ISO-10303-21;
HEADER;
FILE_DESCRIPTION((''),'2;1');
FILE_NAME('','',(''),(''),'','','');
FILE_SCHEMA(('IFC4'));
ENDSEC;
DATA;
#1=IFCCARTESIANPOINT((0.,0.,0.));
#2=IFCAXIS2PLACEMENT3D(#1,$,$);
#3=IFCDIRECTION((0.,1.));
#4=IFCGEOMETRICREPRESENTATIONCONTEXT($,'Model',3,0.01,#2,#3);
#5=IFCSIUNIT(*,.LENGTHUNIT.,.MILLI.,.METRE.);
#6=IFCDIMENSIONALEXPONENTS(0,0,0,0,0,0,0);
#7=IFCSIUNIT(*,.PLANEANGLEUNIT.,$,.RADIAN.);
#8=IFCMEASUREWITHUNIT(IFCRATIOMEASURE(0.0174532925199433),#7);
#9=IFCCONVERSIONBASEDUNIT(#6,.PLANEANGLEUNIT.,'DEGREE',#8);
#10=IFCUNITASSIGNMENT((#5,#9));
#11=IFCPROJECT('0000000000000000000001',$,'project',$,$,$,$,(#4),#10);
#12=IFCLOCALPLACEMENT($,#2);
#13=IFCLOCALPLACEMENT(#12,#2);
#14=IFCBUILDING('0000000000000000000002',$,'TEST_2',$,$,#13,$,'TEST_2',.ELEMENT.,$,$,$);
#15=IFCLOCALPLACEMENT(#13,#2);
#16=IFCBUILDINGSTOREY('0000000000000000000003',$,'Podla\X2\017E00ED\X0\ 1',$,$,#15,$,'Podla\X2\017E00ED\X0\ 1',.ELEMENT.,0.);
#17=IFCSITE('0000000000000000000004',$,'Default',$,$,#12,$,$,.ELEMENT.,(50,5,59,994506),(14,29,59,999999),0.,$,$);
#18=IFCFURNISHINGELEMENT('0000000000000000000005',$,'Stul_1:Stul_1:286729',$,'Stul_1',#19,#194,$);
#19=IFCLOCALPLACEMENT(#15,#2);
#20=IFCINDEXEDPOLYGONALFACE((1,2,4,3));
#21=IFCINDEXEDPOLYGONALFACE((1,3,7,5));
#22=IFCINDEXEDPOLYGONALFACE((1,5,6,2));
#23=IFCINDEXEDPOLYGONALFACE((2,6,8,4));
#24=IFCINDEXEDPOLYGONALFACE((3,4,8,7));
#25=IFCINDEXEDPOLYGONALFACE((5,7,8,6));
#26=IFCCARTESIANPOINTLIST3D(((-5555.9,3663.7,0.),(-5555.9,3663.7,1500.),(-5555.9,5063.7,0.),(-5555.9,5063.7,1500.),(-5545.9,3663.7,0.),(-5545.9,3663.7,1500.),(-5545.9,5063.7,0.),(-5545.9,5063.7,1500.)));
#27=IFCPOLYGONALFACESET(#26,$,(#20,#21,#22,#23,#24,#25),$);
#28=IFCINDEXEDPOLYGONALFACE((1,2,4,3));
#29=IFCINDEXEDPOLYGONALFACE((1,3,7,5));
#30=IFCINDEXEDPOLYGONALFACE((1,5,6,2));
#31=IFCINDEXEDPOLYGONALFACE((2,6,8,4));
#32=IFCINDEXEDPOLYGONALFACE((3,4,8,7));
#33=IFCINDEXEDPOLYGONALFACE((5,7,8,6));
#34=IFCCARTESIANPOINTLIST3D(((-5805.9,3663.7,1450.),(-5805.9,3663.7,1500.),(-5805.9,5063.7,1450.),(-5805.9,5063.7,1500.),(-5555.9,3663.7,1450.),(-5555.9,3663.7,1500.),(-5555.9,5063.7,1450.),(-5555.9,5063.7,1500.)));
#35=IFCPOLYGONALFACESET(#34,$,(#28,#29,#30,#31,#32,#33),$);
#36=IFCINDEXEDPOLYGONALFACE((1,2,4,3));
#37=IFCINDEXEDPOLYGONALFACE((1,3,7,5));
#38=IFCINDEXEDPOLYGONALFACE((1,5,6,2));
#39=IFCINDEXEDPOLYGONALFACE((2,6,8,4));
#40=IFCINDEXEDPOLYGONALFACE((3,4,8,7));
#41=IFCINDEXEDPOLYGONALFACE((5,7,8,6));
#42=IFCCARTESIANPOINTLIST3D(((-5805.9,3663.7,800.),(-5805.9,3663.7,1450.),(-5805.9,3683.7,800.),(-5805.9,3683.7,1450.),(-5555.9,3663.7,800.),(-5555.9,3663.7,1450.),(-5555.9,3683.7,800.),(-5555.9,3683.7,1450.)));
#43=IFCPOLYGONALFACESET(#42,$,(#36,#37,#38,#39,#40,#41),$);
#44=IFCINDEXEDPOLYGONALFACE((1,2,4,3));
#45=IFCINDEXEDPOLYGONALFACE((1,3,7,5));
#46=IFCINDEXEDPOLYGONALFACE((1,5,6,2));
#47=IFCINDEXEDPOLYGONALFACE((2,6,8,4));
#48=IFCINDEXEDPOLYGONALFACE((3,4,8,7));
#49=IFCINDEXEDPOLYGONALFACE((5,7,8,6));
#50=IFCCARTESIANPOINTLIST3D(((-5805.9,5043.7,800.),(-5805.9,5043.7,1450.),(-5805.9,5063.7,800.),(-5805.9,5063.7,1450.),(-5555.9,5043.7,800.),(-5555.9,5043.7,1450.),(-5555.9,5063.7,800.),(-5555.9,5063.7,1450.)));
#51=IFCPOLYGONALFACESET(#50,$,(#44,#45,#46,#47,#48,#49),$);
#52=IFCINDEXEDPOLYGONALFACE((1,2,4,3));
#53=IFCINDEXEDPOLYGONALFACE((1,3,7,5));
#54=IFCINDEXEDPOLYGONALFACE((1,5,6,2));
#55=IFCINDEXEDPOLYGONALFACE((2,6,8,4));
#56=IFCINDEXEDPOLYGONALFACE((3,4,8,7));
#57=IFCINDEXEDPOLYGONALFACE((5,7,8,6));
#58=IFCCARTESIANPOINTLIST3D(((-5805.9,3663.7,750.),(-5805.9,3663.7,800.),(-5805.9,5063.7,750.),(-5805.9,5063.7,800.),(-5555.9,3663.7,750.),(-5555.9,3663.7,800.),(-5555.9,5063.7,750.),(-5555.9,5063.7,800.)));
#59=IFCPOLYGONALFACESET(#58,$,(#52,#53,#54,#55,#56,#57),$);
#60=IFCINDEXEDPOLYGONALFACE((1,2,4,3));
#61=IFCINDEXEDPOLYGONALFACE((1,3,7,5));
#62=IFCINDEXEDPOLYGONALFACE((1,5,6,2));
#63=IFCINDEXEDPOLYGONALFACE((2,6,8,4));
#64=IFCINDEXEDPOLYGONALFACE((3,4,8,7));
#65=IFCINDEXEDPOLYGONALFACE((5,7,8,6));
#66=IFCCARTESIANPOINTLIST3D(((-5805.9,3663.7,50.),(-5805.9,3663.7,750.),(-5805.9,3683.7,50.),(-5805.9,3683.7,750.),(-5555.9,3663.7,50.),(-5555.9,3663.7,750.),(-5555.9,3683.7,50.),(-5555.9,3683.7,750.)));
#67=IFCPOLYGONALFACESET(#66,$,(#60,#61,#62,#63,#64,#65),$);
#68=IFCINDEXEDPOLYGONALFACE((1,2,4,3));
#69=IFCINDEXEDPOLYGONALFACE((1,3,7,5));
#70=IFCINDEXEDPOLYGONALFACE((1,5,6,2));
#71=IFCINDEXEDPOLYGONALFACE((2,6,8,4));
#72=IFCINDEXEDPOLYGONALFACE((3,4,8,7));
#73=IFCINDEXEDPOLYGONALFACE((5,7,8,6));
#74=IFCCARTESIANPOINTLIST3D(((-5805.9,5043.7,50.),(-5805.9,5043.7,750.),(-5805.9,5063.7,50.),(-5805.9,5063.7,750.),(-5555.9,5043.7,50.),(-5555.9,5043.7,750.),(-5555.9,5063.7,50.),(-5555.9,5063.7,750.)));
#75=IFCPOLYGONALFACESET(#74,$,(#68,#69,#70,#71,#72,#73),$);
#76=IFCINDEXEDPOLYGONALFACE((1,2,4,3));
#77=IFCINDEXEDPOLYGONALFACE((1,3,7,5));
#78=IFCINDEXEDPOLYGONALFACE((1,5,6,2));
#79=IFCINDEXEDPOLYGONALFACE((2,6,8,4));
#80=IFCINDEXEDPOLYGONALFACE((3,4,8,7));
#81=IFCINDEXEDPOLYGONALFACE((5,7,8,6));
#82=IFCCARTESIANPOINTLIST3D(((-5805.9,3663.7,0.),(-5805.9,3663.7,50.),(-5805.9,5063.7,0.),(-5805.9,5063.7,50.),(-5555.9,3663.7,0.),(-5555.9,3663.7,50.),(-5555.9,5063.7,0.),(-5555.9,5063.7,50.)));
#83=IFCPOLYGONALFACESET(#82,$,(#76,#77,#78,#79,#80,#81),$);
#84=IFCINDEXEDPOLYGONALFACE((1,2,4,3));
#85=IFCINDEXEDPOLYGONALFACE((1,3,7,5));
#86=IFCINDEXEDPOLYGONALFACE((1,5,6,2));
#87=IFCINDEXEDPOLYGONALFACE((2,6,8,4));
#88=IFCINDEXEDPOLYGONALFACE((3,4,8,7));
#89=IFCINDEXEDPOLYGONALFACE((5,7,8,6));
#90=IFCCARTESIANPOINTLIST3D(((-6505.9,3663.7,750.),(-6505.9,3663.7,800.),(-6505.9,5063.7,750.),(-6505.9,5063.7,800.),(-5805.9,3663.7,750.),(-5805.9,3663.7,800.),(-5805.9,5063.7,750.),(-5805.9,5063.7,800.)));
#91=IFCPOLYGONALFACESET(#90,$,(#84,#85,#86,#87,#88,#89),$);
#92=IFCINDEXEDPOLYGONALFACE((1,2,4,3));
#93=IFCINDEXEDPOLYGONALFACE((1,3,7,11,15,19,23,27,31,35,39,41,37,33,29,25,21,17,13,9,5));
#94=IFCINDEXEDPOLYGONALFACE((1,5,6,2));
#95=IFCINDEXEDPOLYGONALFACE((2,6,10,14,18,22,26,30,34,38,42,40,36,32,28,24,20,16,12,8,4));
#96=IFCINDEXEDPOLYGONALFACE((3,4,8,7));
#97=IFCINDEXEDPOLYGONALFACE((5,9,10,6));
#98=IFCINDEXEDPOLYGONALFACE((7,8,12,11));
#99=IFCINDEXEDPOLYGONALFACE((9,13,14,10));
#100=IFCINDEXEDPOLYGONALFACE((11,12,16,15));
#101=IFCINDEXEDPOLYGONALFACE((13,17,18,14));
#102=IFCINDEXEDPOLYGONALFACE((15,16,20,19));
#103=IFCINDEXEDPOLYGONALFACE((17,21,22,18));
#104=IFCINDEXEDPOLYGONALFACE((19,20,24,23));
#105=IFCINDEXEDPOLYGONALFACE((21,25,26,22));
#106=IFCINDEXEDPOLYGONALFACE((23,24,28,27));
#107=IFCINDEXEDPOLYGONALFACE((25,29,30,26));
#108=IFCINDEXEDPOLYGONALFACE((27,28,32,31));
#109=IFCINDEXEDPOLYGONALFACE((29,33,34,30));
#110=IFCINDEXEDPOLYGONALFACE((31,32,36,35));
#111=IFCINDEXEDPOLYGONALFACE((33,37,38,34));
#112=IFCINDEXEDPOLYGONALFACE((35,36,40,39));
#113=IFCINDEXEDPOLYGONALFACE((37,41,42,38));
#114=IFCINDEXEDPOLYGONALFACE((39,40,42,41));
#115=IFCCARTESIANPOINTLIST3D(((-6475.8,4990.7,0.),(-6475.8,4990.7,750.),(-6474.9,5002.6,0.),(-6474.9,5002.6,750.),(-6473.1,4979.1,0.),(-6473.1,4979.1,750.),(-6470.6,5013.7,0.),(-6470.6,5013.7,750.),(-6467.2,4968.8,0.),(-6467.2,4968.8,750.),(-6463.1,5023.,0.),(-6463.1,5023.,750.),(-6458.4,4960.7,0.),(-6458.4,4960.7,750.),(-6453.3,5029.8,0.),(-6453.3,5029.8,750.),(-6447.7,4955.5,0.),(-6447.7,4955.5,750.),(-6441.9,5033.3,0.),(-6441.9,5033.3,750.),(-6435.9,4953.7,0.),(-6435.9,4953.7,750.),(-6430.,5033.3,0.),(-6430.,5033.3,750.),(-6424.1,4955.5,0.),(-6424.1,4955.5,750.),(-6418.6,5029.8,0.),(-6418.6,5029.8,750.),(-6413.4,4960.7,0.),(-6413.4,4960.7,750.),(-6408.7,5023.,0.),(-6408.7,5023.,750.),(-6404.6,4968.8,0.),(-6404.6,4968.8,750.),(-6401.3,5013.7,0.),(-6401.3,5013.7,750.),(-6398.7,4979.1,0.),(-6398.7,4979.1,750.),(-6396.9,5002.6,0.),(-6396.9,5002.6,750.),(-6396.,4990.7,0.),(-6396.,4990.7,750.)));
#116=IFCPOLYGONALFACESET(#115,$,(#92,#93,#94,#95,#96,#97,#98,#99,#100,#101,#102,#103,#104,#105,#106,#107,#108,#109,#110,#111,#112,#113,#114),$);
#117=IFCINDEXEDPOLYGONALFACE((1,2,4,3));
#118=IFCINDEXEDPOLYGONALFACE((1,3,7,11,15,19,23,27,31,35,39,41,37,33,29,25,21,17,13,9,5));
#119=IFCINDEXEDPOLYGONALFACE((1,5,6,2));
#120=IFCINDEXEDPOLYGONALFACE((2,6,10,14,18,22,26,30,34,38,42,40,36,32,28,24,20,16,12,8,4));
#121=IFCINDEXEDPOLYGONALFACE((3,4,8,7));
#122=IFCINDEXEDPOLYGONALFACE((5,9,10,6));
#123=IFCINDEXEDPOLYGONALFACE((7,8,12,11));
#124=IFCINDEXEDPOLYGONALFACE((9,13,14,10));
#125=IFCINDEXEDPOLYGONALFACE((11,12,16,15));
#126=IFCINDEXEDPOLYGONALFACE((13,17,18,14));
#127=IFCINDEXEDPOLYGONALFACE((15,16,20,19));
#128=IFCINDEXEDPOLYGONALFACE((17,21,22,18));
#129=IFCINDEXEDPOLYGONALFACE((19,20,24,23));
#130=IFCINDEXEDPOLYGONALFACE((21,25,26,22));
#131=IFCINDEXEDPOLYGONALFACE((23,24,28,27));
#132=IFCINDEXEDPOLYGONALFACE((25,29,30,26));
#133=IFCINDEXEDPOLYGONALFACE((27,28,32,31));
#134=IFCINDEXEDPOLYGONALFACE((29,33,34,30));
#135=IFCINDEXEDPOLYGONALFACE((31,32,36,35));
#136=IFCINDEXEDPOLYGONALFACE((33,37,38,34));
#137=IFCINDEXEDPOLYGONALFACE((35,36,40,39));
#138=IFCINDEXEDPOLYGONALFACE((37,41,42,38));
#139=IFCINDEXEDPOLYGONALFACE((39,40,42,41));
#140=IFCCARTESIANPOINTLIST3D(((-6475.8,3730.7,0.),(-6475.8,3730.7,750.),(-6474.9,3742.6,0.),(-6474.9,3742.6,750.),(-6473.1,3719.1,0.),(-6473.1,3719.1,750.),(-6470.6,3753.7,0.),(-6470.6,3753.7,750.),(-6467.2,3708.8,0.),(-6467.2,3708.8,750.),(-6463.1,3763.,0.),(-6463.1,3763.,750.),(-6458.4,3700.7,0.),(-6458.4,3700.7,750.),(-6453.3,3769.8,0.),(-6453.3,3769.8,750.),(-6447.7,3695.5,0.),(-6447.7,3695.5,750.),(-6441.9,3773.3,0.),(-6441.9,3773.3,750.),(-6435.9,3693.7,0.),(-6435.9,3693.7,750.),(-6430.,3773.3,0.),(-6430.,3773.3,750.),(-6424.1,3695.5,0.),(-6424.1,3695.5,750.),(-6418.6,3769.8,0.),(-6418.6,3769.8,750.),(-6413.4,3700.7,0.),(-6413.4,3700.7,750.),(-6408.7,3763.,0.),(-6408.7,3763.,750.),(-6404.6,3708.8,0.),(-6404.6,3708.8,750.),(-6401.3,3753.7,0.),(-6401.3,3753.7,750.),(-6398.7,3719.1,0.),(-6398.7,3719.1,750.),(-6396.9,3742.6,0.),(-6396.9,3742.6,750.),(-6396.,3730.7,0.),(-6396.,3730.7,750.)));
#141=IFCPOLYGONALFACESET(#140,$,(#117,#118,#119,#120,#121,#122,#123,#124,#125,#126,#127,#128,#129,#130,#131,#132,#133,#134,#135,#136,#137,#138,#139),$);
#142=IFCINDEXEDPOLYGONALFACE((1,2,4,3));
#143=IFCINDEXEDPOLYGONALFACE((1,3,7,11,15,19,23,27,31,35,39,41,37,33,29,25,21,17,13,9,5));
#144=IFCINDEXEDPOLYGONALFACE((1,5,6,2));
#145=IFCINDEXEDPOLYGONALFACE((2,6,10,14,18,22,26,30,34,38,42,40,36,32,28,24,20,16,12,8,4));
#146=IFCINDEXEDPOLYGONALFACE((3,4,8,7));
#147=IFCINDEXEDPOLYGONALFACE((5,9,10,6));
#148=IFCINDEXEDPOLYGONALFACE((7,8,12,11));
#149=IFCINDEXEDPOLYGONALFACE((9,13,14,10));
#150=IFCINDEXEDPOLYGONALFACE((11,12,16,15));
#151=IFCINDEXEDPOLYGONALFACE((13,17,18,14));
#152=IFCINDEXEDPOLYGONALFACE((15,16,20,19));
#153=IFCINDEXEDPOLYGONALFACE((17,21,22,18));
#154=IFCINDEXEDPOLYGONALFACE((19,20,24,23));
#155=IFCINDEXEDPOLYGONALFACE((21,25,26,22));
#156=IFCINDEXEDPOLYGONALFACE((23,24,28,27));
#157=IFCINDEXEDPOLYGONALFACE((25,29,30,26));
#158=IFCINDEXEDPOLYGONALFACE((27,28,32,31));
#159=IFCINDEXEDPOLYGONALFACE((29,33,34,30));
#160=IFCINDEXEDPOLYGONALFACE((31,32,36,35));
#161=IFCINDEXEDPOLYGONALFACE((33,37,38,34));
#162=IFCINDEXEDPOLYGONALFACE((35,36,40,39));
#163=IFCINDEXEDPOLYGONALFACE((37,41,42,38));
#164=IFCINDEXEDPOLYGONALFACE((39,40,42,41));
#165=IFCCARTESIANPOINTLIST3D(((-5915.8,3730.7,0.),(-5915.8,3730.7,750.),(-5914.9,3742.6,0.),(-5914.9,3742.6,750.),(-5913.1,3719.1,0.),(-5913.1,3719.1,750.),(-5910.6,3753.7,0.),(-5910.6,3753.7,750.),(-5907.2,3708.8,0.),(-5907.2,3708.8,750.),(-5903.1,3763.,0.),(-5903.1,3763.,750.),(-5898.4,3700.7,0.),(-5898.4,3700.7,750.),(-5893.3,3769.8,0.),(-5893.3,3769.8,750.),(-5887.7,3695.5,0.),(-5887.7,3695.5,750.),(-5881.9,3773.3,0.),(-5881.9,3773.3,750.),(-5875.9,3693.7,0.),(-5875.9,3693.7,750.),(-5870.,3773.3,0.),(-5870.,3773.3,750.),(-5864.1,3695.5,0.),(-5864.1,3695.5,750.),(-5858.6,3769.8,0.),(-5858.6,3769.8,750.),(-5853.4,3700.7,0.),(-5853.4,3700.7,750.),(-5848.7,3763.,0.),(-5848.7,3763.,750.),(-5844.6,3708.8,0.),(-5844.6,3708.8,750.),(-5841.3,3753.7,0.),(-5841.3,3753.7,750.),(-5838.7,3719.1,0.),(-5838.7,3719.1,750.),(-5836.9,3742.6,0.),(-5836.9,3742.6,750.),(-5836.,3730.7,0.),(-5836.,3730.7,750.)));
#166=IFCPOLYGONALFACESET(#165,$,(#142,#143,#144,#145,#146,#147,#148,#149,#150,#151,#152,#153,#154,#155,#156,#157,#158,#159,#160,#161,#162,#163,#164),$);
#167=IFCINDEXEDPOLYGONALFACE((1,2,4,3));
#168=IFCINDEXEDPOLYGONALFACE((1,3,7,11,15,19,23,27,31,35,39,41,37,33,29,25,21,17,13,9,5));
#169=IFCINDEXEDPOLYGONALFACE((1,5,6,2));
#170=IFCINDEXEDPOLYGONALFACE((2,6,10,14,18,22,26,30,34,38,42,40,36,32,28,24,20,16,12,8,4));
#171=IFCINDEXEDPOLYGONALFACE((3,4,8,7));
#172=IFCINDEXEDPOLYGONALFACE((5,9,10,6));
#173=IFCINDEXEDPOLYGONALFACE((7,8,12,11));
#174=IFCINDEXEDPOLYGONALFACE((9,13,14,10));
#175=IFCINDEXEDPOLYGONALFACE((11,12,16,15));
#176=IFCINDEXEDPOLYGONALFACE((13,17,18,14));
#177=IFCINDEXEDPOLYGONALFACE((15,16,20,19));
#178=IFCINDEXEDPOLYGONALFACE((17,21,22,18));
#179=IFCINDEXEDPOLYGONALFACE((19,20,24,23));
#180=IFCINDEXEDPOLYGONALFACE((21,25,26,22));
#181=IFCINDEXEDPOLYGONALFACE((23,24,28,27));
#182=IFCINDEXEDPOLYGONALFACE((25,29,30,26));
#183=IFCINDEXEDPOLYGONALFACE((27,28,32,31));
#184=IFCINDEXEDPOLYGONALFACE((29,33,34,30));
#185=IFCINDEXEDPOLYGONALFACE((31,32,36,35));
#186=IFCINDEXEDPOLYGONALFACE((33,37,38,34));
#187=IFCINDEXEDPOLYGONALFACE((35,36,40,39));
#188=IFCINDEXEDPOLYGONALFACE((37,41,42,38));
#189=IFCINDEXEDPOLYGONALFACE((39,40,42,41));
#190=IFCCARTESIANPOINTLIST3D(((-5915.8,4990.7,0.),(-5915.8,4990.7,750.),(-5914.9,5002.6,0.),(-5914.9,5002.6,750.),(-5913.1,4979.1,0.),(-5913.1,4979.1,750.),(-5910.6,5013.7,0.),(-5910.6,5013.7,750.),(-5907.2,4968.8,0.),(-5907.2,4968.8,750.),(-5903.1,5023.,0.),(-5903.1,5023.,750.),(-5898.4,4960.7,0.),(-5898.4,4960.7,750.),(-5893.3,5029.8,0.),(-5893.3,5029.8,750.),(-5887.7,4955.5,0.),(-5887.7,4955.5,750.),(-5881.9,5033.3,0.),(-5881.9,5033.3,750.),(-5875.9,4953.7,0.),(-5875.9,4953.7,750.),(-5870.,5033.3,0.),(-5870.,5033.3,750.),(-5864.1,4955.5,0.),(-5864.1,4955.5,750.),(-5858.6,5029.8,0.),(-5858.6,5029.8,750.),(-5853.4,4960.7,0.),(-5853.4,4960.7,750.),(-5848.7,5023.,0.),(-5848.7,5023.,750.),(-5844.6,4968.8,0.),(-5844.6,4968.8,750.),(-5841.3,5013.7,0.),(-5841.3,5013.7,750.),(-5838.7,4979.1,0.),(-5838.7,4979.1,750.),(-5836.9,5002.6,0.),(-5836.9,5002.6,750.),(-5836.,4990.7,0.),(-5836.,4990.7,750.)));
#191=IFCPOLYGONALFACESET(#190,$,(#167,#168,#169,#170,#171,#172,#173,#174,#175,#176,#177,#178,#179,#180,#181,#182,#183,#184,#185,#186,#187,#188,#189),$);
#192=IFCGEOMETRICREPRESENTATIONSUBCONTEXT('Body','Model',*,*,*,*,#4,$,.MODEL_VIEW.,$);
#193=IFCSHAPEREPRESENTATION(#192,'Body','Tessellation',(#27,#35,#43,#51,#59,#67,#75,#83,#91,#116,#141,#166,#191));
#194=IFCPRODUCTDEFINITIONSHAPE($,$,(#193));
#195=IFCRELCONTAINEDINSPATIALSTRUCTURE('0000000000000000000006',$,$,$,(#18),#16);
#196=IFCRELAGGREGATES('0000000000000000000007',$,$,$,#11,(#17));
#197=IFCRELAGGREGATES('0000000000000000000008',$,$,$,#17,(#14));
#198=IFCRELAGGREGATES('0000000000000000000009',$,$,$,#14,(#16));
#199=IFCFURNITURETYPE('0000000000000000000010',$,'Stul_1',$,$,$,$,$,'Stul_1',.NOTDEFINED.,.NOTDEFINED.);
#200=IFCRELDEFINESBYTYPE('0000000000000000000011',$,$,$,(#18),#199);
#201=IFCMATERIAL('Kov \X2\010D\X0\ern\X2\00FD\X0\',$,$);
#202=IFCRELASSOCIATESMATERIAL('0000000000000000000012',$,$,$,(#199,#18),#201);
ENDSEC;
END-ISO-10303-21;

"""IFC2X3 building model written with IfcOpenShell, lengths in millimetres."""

from ifc_helpers import new_model, entity, si_unit, converted_unit, direction, frame, frame_2d, origin, origin_2d_with_axis, place, context, subcontext, project, spatial, rectangle, circle, extrude, source, transform, mapped, material, type_object, type_shapes, element, save


model = new_model("IFC2X3")

# Units and contexts
model_context = context("Model", 3, precision=0.01, world=origin(), true_north=direction((0.0, 1.0)))
body_context = subcontext(model_context, "Body", "Model", "MODEL_VIEW")
ifc_project = project(units=[si_unit("LENGTHUNIT", "METRE", prefix="MILLI"), converted_unit("PLANEANGLEUNIT", "DEGREE", entity("IfcRatioMeasure", 0.0174532925199433), si_unit("PLANEANGLEUNIT", "RADIAN"), dimensions=[0, 0, 0, 0, 0, 0, 0])], contexts=[model_context])

# Site, building, storey
site_placement = place(None, origin())
site = spatial("IfcSite", under=ifc_project, at=site_placement, Name="Default", CompositionType="ELEMENT", RefLatitude=(50, 5, 59, 994506), RefLongitude=(14, 29, 59, 999999), RefElevation=0.0)
building_placement = place(site_placement, origin())
building = spatial("IfcBuilding", under=site, at=building_placement, Name="TEST_2", LongName="TEST_2", CompositionType="ELEMENT")
storey_placement = place(building_placement, origin())
storey = spatial("IfcBuildingStorey", under=building, at=storey_placement, Name="Podlaží 1", LongName="Podlaží 1", CompositionType="ELEMENT", Elevation=0.0)

# Furnishing element
ifc_material_1 = material(Name="Kov černý")
furniture_type = type_object("IfcFurnitureType", Name="Stul_1", ElementType="Stul_1", material=ifc_material_1)
shared_shape_1 = source(origin(), body_context, "Body", "SweptSolid", [
    extrude(rectangle(XDim=1400.0, YDim=10.0, at=origin_2d_with_axis()), frame((0.0, 605.0, 0.0), z_axis=(0.0, 0.0, 1.0), x_axis=(-1.0, 0.0, 0.0)), (0.0, 0.0, 1.0), 1500.0),
    extrude(rectangle(XDim=1400.0, YDim=250.0, at=frame_2d((0.0, 0.0), x_axis=(1.0, 0.0))), frame((0.0, 475.0, 1450.0), z_axis=(0.0, 0.0, 1.0), x_axis=(-1.0, 0.0, 0.0)), (0.0, 0.0, 1.0), 50.0),
    extrude(rectangle(XDim=20.0, YDim=250.0, at=origin_2d_with_axis()), frame((690.0, 475.0, 800.0), z_axis=(0.0, 0.0, 1.0), x_axis=(-1.0, 0.0, 0.0)), (0.0, 0.0, 1.0), 650.0),
    extrude(rectangle(XDim=20.0, YDim=250.0, at=frame_2d((0.0, 0.0), x_axis=(1.0, 0.0))), frame((-690.0, 475.0, 800.0), z_axis=(0.0, 0.0, 1.0), x_axis=(-1.0, 0.0, 0.0)), (0.0, 0.0, 1.0), 650.0),
    extrude(rectangle(XDim=1400.0, YDim=250.0, at=origin_2d_with_axis()), frame((0.0, 475.0, 750.0), z_axis=(0.0, 0.0, 1.0), x_axis=(-1.0, 0.0, 0.0)), (0.0, 0.0, 1.0), 50.0),
    extrude(rectangle(XDim=20.0, YDim=250.0, at=origin_2d_with_axis()), frame((690.0, 475.0, 50.0), z_axis=(0.0, 0.0, 1.0), x_axis=(-1.0, 0.0, 0.0)), (0.0, 0.0, 1.0), 700.0),
    extrude(rectangle(XDim=20.0, YDim=250.0, at=frame_2d((0.0, 0.0), x_axis=(1.0, 0.0))), frame((-690.0, 475.0, 50.0), z_axis=(0.0, 0.0, 1.0), x_axis=(-1.0, 0.0, 0.0)), (0.0, 0.0, 1.0), 700.0),
    extrude(rectangle(XDim=1400.0, YDim=250.0, at=origin_2d_with_axis()), frame((0.0, 475.0, 0.0), z_axis=(0.0, 0.0, 1.0), x_axis=(-1.0, 0.0, 0.0)), (0.0, 0.0, 1.0), 50.0),
    extrude(rectangle(XDim=1400.0, YDim=700.0, at=origin_2d_with_axis()), frame((0.0, 0.0, 750.0), z_axis=(0.0, 0.0, 1.0), x_axis=(-1.0, 0.0, 0.0)), (0.0, 0.0, 1.0), 50.0),
    extrude(circle(Radius=40.0, at=frame_2d((0.0, 0.0), x_axis=(1.0, 0.0))), frame((-630.0, -280.0, 0.0)), (0.0, 0.0, 1.0), 750.0),
    extrude(circle(Radius=40.0, at=frame_2d((0.0, 0.0), x_axis=(1.0, 0.0))), frame((630.0, -280.0, 0.0)), (0.0, 0.0, 1.0), 750.0),
    extrude(circle(Radius=40.0, at=frame_2d((0.0, 0.0), x_axis=(1.0, 0.0))), frame((630.0, 280.0, 0.0)), (0.0, 0.0, 1.0), 750.0),
    extrude(circle(Radius=40.0, at=frame_2d((0.0, 0.0), x_axis=(1.0, 0.0))), frame((-630.0, 280.0, 0.0)), (0.0, 0.0, 1.0), 750.0),
])
type_shapes(furniture_type, [shared_shape_1])
for number, where, z_axis, x_axis, name in (
    (1, (-6155.9, 4363.7, 0.0), (0.0, 0.0, 1.0), (0.0, -1.0, 0.0), "Stul_1:Stul_1:286729"),
):
    element("IfcFurnishingElement", number, at=place(storey_placement, frame(where, z_axis=z_axis, x_axis=x_axis)), inside=storey, type_object=furniture_type, material=ifc_material_1, Name=name, ObjectType="Stul_1", context=body_context, shape_type="MappedRepresentation", body=[
        mapped(shared_shape_1, transform((0.0, 0.0, 0.0), scale=1.0)),
    ])

save(model, "model.ifc")
